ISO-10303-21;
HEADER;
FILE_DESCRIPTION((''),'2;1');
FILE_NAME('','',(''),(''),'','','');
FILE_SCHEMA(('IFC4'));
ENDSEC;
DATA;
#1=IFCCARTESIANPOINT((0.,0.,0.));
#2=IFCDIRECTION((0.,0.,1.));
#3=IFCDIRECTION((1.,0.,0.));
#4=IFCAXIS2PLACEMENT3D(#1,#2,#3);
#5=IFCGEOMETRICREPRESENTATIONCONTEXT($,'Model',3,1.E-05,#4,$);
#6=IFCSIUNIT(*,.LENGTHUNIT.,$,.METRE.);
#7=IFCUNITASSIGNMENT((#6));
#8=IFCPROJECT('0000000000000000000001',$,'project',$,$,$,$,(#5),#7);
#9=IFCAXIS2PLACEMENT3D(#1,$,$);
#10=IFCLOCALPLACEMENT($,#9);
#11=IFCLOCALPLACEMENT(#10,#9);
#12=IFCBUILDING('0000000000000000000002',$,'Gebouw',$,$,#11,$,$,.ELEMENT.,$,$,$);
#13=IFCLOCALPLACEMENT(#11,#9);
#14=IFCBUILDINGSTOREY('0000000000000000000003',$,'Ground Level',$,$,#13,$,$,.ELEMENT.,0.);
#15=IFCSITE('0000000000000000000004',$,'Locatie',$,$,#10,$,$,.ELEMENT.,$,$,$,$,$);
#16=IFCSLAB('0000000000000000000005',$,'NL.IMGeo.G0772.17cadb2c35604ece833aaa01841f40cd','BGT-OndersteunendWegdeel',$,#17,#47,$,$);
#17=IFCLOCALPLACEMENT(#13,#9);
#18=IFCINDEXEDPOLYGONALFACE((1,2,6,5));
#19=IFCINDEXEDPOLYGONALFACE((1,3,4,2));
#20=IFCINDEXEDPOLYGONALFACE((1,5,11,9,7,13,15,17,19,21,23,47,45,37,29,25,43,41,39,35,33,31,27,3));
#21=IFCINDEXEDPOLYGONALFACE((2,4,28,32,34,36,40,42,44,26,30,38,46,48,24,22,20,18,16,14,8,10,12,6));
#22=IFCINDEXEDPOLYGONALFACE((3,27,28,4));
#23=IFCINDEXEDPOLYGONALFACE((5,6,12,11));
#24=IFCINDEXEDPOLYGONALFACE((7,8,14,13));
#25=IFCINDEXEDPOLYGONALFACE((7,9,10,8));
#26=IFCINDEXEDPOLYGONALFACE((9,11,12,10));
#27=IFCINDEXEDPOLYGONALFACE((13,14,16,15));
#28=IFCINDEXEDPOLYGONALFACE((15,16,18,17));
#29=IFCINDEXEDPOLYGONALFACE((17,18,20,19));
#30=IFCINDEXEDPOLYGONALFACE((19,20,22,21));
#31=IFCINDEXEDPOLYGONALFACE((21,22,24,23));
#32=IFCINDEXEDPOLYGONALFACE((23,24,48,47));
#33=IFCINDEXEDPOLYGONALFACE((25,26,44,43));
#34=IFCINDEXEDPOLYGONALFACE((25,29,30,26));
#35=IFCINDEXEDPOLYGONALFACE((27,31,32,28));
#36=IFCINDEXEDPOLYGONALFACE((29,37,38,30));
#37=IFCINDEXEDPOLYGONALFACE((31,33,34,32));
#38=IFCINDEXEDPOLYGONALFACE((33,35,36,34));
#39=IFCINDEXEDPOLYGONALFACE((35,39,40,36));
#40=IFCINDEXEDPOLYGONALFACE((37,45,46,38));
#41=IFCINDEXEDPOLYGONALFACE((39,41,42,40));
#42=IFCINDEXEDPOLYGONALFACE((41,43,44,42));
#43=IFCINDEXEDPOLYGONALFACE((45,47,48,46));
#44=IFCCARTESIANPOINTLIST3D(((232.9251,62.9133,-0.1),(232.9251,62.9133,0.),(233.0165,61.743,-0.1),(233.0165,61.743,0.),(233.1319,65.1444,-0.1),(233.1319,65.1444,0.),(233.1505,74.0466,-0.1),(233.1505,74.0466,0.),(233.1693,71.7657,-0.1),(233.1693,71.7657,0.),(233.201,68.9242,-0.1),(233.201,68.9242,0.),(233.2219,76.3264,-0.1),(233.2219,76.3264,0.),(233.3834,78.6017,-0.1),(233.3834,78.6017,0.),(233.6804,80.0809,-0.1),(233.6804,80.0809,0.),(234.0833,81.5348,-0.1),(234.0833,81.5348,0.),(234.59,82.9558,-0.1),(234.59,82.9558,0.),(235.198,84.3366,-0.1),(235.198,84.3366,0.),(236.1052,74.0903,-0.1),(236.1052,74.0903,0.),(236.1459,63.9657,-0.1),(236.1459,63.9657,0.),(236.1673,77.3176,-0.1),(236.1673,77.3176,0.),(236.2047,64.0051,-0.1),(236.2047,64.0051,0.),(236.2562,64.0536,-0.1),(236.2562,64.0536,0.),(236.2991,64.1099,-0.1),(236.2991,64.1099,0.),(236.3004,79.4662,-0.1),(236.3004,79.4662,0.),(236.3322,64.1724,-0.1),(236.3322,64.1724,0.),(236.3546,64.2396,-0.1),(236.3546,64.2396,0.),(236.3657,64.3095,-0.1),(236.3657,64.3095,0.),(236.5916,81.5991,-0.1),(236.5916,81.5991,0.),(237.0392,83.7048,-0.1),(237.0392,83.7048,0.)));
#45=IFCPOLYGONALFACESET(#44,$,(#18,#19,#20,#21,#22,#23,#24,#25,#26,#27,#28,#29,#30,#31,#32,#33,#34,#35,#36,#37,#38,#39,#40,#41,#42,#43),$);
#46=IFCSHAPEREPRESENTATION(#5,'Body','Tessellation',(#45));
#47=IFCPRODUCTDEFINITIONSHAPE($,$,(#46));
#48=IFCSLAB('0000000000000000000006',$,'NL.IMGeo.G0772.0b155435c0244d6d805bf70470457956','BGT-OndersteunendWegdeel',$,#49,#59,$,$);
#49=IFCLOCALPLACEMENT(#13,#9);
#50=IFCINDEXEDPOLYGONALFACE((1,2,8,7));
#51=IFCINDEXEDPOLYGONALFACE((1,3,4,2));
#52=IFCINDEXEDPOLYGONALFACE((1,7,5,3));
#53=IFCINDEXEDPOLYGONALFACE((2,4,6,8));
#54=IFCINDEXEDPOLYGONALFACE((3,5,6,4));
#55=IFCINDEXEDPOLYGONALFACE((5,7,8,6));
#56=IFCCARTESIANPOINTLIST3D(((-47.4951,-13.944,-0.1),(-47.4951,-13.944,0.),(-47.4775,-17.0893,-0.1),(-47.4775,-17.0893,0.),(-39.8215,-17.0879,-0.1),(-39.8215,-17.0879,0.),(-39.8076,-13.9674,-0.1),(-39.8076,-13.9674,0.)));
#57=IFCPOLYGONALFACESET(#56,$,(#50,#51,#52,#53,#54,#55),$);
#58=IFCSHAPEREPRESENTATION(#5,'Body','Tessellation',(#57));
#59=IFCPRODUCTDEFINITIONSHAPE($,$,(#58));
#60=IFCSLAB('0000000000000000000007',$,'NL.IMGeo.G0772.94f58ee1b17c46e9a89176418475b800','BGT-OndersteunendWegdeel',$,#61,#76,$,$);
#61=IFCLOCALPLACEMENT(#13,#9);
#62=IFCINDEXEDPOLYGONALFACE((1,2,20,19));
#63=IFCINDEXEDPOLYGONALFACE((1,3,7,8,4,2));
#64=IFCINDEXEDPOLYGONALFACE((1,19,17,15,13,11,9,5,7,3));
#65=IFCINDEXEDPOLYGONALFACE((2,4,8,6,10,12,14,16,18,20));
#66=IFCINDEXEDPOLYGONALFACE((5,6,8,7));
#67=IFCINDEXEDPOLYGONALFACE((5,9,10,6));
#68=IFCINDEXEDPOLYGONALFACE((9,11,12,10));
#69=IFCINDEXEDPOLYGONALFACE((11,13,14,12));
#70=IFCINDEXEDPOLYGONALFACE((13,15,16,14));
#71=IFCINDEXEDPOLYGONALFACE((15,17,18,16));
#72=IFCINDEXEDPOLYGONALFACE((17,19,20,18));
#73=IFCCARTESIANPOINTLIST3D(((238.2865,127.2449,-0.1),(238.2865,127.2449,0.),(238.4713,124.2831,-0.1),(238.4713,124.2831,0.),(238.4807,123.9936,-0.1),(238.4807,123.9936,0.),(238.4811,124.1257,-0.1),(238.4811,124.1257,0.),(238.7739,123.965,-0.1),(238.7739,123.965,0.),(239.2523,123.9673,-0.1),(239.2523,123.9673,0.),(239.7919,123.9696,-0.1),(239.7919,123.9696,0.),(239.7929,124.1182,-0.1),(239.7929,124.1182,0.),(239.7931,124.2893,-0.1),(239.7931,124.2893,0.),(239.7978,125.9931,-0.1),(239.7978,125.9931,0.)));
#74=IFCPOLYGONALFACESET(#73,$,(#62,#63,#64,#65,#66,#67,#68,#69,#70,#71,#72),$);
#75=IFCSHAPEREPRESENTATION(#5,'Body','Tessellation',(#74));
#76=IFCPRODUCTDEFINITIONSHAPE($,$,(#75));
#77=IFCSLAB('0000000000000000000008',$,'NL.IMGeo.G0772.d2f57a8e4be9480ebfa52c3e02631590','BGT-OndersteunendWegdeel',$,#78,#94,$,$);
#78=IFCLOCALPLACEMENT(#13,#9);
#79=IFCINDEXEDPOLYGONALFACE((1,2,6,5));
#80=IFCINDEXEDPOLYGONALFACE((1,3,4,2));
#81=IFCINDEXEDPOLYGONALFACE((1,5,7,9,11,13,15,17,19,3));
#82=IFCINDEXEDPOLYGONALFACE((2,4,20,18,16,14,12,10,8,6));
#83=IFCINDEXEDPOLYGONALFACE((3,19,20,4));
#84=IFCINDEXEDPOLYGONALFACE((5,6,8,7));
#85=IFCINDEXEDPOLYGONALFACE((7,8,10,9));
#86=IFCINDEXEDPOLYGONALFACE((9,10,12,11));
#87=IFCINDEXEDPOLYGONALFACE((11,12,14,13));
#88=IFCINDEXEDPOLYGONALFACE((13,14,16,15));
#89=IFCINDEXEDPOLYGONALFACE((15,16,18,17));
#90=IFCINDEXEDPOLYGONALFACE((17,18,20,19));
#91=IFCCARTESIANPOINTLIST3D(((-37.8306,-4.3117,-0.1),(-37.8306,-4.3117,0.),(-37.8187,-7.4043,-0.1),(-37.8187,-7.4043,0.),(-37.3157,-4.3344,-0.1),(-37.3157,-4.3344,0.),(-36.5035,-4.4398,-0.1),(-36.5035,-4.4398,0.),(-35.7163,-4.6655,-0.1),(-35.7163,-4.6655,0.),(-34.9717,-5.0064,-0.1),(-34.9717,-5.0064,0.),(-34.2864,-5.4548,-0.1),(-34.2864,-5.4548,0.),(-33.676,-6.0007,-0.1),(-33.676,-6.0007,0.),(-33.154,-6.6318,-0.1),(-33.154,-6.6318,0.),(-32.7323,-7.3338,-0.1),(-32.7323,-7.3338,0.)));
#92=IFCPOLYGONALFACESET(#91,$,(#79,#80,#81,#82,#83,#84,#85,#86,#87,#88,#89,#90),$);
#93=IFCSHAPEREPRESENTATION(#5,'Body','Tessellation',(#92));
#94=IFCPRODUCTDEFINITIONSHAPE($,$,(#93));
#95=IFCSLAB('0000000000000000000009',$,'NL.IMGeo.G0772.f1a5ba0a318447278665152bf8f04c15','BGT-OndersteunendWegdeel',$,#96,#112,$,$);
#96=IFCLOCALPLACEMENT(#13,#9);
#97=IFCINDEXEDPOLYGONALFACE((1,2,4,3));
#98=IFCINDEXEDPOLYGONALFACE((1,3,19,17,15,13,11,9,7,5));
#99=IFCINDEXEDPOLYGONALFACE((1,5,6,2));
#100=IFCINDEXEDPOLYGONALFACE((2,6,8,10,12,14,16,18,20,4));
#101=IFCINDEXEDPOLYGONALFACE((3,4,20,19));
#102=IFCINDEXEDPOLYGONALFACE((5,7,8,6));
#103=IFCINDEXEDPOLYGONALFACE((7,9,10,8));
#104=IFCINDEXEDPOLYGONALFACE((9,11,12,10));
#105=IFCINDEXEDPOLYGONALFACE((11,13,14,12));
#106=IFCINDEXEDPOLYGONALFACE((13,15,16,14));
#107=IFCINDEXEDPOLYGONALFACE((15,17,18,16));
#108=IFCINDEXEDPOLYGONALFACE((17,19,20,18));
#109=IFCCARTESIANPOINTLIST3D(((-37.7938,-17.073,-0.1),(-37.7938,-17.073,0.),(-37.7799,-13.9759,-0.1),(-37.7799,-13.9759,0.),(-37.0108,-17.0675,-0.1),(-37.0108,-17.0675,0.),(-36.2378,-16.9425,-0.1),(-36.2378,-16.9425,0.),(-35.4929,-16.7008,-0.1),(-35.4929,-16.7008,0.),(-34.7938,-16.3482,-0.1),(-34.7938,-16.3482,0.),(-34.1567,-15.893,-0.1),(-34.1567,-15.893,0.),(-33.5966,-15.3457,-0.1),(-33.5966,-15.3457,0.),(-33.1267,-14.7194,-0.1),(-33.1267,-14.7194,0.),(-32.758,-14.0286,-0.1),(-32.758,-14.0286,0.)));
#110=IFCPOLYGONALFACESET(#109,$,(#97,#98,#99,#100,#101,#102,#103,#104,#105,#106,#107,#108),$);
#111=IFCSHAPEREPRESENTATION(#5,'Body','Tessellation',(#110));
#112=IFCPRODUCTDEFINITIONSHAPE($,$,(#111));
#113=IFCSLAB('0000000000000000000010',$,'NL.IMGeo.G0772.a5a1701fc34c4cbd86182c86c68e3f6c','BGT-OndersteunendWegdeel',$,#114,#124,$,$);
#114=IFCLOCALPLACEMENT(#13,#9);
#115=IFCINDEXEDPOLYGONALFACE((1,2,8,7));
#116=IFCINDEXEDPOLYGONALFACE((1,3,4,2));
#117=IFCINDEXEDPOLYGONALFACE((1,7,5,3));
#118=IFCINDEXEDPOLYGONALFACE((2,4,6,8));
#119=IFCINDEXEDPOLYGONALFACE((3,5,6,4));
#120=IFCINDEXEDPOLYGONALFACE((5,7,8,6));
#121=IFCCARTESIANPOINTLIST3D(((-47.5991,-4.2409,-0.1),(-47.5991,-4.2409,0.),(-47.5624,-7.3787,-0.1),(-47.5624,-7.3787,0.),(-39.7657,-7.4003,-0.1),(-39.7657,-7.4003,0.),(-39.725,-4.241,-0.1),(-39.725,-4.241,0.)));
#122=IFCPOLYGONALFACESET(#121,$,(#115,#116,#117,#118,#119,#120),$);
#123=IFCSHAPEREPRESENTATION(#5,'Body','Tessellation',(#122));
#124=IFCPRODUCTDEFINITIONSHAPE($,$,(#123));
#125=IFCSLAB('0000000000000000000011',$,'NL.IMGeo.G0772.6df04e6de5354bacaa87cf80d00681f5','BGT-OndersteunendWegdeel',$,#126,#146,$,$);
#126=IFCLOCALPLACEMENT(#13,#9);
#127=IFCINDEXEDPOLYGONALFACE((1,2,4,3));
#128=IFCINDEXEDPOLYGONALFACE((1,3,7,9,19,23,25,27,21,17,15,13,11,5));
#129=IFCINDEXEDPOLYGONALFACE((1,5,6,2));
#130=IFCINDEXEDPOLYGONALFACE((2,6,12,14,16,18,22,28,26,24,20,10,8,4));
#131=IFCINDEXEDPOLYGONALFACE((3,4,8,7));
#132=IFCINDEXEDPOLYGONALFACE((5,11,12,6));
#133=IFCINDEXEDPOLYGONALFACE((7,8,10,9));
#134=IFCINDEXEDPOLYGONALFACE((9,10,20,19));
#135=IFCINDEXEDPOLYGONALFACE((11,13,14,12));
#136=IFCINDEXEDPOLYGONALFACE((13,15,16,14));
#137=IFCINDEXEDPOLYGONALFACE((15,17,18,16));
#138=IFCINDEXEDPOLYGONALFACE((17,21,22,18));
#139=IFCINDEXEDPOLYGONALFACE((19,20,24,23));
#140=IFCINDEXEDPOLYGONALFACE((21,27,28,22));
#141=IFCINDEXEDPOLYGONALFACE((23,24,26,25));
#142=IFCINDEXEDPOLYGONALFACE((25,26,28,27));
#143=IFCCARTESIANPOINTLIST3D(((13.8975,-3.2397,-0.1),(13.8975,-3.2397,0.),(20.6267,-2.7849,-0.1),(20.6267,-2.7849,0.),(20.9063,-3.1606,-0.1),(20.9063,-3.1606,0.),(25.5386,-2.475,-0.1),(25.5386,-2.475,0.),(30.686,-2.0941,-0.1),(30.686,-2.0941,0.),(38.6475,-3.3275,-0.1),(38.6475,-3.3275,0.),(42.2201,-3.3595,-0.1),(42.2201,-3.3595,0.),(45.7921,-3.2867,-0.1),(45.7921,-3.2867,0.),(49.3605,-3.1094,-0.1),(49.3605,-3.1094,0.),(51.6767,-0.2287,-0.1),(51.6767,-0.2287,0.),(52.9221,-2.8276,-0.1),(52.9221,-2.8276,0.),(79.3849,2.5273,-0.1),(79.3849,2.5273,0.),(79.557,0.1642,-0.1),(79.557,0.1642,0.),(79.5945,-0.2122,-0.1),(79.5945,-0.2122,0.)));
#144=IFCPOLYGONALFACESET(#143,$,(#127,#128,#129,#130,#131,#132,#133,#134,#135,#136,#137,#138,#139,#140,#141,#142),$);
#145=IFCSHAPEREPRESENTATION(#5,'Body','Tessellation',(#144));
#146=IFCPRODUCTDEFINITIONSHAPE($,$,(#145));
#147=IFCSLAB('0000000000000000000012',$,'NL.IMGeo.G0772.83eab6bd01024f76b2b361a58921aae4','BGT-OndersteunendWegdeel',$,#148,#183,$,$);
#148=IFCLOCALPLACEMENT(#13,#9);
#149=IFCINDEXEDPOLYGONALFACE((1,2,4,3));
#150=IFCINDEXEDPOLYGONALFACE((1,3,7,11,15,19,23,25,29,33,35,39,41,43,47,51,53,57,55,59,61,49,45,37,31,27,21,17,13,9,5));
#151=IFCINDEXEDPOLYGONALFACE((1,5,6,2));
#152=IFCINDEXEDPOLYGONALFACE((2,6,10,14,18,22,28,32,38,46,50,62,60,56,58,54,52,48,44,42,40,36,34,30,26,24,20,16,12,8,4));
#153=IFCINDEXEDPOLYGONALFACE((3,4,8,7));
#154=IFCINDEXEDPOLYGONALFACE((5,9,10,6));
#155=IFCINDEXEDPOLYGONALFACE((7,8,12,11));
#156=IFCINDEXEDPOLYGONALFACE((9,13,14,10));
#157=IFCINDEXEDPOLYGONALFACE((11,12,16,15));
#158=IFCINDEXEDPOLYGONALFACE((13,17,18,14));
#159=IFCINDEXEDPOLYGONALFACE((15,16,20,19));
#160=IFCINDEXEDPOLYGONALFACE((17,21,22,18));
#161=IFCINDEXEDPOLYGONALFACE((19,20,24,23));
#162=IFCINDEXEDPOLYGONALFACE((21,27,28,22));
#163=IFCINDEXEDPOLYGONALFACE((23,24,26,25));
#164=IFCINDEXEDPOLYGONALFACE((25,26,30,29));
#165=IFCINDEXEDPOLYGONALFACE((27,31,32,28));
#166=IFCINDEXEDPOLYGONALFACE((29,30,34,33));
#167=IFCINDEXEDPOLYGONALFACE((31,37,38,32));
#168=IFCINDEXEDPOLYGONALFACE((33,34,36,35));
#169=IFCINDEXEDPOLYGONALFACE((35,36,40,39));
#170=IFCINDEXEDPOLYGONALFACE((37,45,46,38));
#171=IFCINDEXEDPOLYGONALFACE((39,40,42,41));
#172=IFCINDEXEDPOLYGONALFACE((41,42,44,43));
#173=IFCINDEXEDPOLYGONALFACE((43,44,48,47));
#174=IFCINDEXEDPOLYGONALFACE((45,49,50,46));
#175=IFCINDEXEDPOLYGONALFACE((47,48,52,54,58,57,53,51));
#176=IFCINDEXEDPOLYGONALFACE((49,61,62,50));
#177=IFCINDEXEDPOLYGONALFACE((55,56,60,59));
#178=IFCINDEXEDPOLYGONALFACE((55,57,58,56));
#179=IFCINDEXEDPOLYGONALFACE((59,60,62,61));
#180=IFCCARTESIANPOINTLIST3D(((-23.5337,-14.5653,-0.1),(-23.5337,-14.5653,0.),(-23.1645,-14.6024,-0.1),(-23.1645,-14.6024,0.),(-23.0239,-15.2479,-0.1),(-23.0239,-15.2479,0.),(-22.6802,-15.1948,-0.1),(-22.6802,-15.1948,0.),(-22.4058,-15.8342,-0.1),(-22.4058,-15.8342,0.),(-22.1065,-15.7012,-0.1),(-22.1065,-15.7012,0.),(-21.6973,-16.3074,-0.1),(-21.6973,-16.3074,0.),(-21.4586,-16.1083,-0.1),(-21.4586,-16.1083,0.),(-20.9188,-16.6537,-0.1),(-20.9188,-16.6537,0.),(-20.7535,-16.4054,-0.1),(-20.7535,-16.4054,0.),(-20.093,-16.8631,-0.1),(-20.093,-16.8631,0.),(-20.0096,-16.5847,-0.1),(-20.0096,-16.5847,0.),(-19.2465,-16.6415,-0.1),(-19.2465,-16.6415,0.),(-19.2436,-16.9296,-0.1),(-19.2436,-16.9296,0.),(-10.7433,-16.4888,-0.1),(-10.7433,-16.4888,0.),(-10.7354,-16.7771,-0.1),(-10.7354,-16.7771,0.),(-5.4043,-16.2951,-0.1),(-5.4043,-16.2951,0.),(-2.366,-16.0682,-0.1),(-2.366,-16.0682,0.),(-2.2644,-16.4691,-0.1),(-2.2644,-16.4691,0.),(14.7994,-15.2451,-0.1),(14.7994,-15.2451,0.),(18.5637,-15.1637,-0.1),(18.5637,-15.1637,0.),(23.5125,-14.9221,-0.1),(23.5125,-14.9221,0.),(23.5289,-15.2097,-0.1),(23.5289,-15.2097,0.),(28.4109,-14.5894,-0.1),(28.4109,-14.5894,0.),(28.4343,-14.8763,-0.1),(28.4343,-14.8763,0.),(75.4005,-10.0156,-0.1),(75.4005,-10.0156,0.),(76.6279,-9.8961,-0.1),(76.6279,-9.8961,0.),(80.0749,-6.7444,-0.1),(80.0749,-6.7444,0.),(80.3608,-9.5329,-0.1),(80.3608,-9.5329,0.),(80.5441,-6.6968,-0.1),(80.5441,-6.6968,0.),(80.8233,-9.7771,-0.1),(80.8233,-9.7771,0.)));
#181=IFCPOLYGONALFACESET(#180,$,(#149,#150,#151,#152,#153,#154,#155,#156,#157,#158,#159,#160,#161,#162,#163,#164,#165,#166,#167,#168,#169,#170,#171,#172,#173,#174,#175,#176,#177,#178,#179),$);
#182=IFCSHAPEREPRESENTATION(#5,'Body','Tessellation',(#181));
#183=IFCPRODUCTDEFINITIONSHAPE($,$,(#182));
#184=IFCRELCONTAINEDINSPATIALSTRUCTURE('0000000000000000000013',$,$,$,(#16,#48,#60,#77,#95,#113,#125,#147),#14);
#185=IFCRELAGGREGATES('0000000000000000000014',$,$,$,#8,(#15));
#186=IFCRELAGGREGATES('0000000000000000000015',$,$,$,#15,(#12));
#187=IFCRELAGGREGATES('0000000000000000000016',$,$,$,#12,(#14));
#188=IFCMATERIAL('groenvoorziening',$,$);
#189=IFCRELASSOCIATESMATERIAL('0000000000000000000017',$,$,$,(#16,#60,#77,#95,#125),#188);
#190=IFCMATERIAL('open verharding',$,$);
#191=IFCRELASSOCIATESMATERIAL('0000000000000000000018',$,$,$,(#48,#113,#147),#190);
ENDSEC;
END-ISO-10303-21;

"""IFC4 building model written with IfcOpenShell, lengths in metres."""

from ifc_helpers import new_model, si_unit, frame, origin, origin_with_axes, place, context, project, spatial, polyline, outline, extrude, material, element, save


model = new_model("IFC4")

# Units and contexts
model_context = context("Model", 3, precision=1e-05, world=origin_with_axes())
ifc_project = project(units=[si_unit("LENGTHUNIT", "METRE")], contexts=[model_context])

# Site, building, storey
site_placement = place(None, origin())
site = spatial("IfcSite", under=ifc_project, at=site_placement, Name="Locatie", CompositionType="ELEMENT")
building_placement = place(site_placement, origin())
building = spatial("IfcBuilding", under=site, at=building_placement, Name="Gebouw", CompositionType="ELEMENT")
storey_placement = place(building_placement, origin())
storey = spatial("IfcBuildingStorey", under=building, at=storey_placement, Name="Ground Level", CompositionType="ELEMENT", Elevation=0.0)

# Slabs
ifc_material_1 = material(Name="open verharding")
ifc_material_2 = material(Name="groenvoorziening")
slab_1_placement = place(storey_placement, origin())
element("IfcSlab", 1, at=slab_1_placement, inside=storey, material=ifc_material_2, Name="NL.IMGeo.G0772.17cadb2c35604ece833aaa01841f40cd", Description="BGT-OndersteunendWegdeel", context=model_context, shape_type="SweptSolid", body=[
    extrude(outline(polyline([(236.3657, 64.3095), (236.3546, 64.2396), (236.3322, 64.1724), (236.2991, 64.1099), (236.2562, 64.0536), (236.2047, 64.0051), (236.1459, 63.9657), (233.0165, 61.743), (232.9251, 62.9133), (233.1319, 65.1444), (233.201, 68.9242), (233.1693, 71.7657), (233.1505, 74.0466), (233.2219, 76.3264), (233.3834, 78.6017), (233.6804, 80.0809), (234.0833, 81.5348), (234.59, 82.9558), (235.198, 84.3366), (237.0392, 83.7048), (236.5916, 81.5991), (236.3004, 79.4662), (236.1673, 77.3176), (236.1052, 74.0903), (236.3657, 64.3095)])), frame((0.0, 0.0, -0.1), z_axis=(0.0, 0.0, 1.0), x_axis=(1.0, 0.0, 0.0)), (0.0, 0.0, 1.0), 0.1),
])
slab_2_placement = place(storey_placement, origin())
element("IfcSlab", 2, at=slab_2_placement, inside=storey, material=ifc_material_1, Name="NL.IMGeo.G0772.0b155435c0244d6d805bf70470457956", Description="BGT-OndersteunendWegdeel", context=model_context, shape_type="SweptSolid", body=[
    extrude(outline(polyline([(-39.8076, -13.9674), (-39.8215, -17.0879), (-47.4775, -17.0893), (-47.4951, -13.944), (-39.8076, -13.9674)])), frame((0.0, 0.0, -0.1), z_axis=(0.0, 0.0, 1.0), x_axis=(1.0, 0.0, 0.0)), (0.0, 0.0, 1.0), 0.1),
])
slab_3_placement = place(storey_placement, origin())
element("IfcSlab", 3, at=slab_3_placement, inside=storey, material=ifc_material_2, Name="NL.IMGeo.G0772.94f58ee1b17c46e9a89176418475b800", Description="BGT-OndersteunendWegdeel", context=model_context, shape_type="SweptSolid", body=[
    extrude(outline(polyline([(239.7931, 124.2893), (239.7929, 124.1182), (239.7919, 123.9696), (239.2523, 123.9673), (238.7739, 123.965), (238.4807, 123.9936), (238.4811, 124.1257), (238.4713, 124.2831), (238.2865, 127.2449), (239.7978, 125.9931), (239.7931, 124.2893)])), frame((0.0, 0.0, -0.1), z_axis=(0.0, 0.0, 1.0), x_axis=(1.0, 0.0, 0.0)), (0.0, 0.0, 1.0), 0.1),
])
slab_4_placement = place(storey_placement, origin())
element("IfcSlab", 4, at=slab_4_placement, inside=storey, material=ifc_material_2, Name="NL.IMGeo.G0772.d2f57a8e4be9480ebfa52c3e02631590", Description="BGT-OndersteunendWegdeel", context=model_context, shape_type="SweptSolid", body=[
    extrude(outline(polyline([(-36.5035, -4.4398), (-35.7163, -4.6655), (-34.9717, -5.0064), (-34.2864, -5.4548), (-33.676, -6.0007), (-33.154, -6.6318), (-32.7323, -7.3338), (-37.8187, -7.4043), (-37.8306, -4.3117), (-37.3157, -4.3344), (-36.5035, -4.4398)])), frame((0.0, 0.0, -0.1), z_axis=(0.0, 0.0, 1.0), x_axis=(1.0, 0.0, 0.0)), (0.0, 0.0, 1.0), 0.1),
])
slab_5_placement = place(storey_placement, origin())
element("IfcSlab", 5, at=slab_5_placement, inside=storey, material=ifc_material_2, Name="NL.IMGeo.G0772.f1a5ba0a318447278665152bf8f04c15", Description="BGT-OndersteunendWegdeel", context=model_context, shape_type="SweptSolid", body=[
    extrude(outline(polyline([(-32.758, -14.0286), (-33.1267, -14.7194), (-33.5966, -15.3457), (-34.1567, -15.893), (-34.7938, -16.3482), (-35.4929, -16.7008), (-36.2378, -16.9425), (-37.0108, -17.0675), (-37.7938, -17.073), (-37.7799, -13.9759), (-32.758, -14.0286)])), frame((0.0, 0.0, -0.1), z_axis=(0.0, 0.0, 1.0), x_axis=(1.0, 0.0, 0.0)), (0.0, 0.0, 1.0), 0.1),
])
slab_6_placement = place(storey_placement, origin())
element("IfcSlab", 6, at=slab_6_placement, inside=storey, material=ifc_material_1, Name="NL.IMGeo.G0772.a5a1701fc34c4cbd86182c86c68e3f6c", Description="BGT-OndersteunendWegdeel", context=model_context, shape_type="SweptSolid", body=[
    extrude(outline(polyline([(-39.725, -4.241), (-39.7657, -7.4003), (-47.5624, -7.3787), (-47.5991, -4.2409), (-39.725, -4.241)])), frame((0.0, 0.0, -0.1), z_axis=(0.0, 0.0, 1.0), x_axis=(1.0, 0.0, 0.0)), (0.0, 0.0, 1.0), 0.1),
])
slab_7_placement = place(storey_placement, origin())
element("IfcSlab", 7, at=slab_7_placement, inside=storey, material=ifc_material_2, Name="NL.IMGeo.G0772.6df04e6de5354bacaa87cf80d00681f5", Description="BGT-OndersteunendWegdeel", context=model_context, shape_type="SweptSolid", body=[
    extrude(outline(polyline([(20.6267, -2.7849), (25.5386, -2.475), (30.686, -2.0941), (51.6767, -0.2287), (79.3849, 2.5273), (79.557, 0.1642), (79.5945, -0.2122), (52.9221, -2.8276), (49.3605, -3.1094), (45.7921, -3.2867), (42.2201, -3.3595), (38.6475, -3.3275), (20.9063, -3.1606), (13.8975, -3.2397), (20.6267, -2.7849)])), frame((0.0, 0.0, -0.1), z_axis=(0.0, 0.0, 1.0), x_axis=(1.0, 0.0, 0.0)), (0.0, 0.0, 1.0), 0.1),
])
slab_8_placement = place(storey_placement, origin())
element("IfcSlab", 8, at=slab_8_placement, inside=storey, material=ifc_material_1, Name="NL.IMGeo.G0772.83eab6bd01024f76b2b361a58921aae4", Description="BGT-OndersteunendWegdeel", context=model_context, shape_type="SweptSolid", body=[
    extrude(outline(polyline([(18.5637, -15.1637), (23.5125, -14.9221), (28.4109, -14.5894), (75.4005, -10.0156), (76.6279, -9.8961), (80.3608, -9.5329), (80.0749, -6.7444), (80.5441, -6.6968), (80.8233, -9.7771), (28.4343, -14.8763), (23.5289, -15.2097), (-2.2644, -16.4691), (-10.7354, -16.7771), (-19.2436, -16.9296), (-20.093, -16.8631), (-20.9188, -16.6537), (-21.6973, -16.3074), (-22.4058, -15.8342), (-23.0239, -15.2479), (-23.5337, -14.5653), (-23.1645, -14.6024), (-22.6802, -15.1948), (-22.1065, -15.7012), (-21.4586, -16.1083), (-20.7535, -16.4054), (-20.0096, -16.5847), (-19.2465, -16.6415), (-10.7433, -16.4888), (-5.4043, -16.2951), (-2.366, -16.0682), (14.7994, -15.2451), (18.5637, -15.1637)])), frame((0.0, 0.0, -0.1), z_axis=(0.0, 0.0, 1.0), x_axis=(1.0, 0.0, 0.0)), (0.0, 0.0, 1.0), 0.1),
])

save(model, "model.ifc")
